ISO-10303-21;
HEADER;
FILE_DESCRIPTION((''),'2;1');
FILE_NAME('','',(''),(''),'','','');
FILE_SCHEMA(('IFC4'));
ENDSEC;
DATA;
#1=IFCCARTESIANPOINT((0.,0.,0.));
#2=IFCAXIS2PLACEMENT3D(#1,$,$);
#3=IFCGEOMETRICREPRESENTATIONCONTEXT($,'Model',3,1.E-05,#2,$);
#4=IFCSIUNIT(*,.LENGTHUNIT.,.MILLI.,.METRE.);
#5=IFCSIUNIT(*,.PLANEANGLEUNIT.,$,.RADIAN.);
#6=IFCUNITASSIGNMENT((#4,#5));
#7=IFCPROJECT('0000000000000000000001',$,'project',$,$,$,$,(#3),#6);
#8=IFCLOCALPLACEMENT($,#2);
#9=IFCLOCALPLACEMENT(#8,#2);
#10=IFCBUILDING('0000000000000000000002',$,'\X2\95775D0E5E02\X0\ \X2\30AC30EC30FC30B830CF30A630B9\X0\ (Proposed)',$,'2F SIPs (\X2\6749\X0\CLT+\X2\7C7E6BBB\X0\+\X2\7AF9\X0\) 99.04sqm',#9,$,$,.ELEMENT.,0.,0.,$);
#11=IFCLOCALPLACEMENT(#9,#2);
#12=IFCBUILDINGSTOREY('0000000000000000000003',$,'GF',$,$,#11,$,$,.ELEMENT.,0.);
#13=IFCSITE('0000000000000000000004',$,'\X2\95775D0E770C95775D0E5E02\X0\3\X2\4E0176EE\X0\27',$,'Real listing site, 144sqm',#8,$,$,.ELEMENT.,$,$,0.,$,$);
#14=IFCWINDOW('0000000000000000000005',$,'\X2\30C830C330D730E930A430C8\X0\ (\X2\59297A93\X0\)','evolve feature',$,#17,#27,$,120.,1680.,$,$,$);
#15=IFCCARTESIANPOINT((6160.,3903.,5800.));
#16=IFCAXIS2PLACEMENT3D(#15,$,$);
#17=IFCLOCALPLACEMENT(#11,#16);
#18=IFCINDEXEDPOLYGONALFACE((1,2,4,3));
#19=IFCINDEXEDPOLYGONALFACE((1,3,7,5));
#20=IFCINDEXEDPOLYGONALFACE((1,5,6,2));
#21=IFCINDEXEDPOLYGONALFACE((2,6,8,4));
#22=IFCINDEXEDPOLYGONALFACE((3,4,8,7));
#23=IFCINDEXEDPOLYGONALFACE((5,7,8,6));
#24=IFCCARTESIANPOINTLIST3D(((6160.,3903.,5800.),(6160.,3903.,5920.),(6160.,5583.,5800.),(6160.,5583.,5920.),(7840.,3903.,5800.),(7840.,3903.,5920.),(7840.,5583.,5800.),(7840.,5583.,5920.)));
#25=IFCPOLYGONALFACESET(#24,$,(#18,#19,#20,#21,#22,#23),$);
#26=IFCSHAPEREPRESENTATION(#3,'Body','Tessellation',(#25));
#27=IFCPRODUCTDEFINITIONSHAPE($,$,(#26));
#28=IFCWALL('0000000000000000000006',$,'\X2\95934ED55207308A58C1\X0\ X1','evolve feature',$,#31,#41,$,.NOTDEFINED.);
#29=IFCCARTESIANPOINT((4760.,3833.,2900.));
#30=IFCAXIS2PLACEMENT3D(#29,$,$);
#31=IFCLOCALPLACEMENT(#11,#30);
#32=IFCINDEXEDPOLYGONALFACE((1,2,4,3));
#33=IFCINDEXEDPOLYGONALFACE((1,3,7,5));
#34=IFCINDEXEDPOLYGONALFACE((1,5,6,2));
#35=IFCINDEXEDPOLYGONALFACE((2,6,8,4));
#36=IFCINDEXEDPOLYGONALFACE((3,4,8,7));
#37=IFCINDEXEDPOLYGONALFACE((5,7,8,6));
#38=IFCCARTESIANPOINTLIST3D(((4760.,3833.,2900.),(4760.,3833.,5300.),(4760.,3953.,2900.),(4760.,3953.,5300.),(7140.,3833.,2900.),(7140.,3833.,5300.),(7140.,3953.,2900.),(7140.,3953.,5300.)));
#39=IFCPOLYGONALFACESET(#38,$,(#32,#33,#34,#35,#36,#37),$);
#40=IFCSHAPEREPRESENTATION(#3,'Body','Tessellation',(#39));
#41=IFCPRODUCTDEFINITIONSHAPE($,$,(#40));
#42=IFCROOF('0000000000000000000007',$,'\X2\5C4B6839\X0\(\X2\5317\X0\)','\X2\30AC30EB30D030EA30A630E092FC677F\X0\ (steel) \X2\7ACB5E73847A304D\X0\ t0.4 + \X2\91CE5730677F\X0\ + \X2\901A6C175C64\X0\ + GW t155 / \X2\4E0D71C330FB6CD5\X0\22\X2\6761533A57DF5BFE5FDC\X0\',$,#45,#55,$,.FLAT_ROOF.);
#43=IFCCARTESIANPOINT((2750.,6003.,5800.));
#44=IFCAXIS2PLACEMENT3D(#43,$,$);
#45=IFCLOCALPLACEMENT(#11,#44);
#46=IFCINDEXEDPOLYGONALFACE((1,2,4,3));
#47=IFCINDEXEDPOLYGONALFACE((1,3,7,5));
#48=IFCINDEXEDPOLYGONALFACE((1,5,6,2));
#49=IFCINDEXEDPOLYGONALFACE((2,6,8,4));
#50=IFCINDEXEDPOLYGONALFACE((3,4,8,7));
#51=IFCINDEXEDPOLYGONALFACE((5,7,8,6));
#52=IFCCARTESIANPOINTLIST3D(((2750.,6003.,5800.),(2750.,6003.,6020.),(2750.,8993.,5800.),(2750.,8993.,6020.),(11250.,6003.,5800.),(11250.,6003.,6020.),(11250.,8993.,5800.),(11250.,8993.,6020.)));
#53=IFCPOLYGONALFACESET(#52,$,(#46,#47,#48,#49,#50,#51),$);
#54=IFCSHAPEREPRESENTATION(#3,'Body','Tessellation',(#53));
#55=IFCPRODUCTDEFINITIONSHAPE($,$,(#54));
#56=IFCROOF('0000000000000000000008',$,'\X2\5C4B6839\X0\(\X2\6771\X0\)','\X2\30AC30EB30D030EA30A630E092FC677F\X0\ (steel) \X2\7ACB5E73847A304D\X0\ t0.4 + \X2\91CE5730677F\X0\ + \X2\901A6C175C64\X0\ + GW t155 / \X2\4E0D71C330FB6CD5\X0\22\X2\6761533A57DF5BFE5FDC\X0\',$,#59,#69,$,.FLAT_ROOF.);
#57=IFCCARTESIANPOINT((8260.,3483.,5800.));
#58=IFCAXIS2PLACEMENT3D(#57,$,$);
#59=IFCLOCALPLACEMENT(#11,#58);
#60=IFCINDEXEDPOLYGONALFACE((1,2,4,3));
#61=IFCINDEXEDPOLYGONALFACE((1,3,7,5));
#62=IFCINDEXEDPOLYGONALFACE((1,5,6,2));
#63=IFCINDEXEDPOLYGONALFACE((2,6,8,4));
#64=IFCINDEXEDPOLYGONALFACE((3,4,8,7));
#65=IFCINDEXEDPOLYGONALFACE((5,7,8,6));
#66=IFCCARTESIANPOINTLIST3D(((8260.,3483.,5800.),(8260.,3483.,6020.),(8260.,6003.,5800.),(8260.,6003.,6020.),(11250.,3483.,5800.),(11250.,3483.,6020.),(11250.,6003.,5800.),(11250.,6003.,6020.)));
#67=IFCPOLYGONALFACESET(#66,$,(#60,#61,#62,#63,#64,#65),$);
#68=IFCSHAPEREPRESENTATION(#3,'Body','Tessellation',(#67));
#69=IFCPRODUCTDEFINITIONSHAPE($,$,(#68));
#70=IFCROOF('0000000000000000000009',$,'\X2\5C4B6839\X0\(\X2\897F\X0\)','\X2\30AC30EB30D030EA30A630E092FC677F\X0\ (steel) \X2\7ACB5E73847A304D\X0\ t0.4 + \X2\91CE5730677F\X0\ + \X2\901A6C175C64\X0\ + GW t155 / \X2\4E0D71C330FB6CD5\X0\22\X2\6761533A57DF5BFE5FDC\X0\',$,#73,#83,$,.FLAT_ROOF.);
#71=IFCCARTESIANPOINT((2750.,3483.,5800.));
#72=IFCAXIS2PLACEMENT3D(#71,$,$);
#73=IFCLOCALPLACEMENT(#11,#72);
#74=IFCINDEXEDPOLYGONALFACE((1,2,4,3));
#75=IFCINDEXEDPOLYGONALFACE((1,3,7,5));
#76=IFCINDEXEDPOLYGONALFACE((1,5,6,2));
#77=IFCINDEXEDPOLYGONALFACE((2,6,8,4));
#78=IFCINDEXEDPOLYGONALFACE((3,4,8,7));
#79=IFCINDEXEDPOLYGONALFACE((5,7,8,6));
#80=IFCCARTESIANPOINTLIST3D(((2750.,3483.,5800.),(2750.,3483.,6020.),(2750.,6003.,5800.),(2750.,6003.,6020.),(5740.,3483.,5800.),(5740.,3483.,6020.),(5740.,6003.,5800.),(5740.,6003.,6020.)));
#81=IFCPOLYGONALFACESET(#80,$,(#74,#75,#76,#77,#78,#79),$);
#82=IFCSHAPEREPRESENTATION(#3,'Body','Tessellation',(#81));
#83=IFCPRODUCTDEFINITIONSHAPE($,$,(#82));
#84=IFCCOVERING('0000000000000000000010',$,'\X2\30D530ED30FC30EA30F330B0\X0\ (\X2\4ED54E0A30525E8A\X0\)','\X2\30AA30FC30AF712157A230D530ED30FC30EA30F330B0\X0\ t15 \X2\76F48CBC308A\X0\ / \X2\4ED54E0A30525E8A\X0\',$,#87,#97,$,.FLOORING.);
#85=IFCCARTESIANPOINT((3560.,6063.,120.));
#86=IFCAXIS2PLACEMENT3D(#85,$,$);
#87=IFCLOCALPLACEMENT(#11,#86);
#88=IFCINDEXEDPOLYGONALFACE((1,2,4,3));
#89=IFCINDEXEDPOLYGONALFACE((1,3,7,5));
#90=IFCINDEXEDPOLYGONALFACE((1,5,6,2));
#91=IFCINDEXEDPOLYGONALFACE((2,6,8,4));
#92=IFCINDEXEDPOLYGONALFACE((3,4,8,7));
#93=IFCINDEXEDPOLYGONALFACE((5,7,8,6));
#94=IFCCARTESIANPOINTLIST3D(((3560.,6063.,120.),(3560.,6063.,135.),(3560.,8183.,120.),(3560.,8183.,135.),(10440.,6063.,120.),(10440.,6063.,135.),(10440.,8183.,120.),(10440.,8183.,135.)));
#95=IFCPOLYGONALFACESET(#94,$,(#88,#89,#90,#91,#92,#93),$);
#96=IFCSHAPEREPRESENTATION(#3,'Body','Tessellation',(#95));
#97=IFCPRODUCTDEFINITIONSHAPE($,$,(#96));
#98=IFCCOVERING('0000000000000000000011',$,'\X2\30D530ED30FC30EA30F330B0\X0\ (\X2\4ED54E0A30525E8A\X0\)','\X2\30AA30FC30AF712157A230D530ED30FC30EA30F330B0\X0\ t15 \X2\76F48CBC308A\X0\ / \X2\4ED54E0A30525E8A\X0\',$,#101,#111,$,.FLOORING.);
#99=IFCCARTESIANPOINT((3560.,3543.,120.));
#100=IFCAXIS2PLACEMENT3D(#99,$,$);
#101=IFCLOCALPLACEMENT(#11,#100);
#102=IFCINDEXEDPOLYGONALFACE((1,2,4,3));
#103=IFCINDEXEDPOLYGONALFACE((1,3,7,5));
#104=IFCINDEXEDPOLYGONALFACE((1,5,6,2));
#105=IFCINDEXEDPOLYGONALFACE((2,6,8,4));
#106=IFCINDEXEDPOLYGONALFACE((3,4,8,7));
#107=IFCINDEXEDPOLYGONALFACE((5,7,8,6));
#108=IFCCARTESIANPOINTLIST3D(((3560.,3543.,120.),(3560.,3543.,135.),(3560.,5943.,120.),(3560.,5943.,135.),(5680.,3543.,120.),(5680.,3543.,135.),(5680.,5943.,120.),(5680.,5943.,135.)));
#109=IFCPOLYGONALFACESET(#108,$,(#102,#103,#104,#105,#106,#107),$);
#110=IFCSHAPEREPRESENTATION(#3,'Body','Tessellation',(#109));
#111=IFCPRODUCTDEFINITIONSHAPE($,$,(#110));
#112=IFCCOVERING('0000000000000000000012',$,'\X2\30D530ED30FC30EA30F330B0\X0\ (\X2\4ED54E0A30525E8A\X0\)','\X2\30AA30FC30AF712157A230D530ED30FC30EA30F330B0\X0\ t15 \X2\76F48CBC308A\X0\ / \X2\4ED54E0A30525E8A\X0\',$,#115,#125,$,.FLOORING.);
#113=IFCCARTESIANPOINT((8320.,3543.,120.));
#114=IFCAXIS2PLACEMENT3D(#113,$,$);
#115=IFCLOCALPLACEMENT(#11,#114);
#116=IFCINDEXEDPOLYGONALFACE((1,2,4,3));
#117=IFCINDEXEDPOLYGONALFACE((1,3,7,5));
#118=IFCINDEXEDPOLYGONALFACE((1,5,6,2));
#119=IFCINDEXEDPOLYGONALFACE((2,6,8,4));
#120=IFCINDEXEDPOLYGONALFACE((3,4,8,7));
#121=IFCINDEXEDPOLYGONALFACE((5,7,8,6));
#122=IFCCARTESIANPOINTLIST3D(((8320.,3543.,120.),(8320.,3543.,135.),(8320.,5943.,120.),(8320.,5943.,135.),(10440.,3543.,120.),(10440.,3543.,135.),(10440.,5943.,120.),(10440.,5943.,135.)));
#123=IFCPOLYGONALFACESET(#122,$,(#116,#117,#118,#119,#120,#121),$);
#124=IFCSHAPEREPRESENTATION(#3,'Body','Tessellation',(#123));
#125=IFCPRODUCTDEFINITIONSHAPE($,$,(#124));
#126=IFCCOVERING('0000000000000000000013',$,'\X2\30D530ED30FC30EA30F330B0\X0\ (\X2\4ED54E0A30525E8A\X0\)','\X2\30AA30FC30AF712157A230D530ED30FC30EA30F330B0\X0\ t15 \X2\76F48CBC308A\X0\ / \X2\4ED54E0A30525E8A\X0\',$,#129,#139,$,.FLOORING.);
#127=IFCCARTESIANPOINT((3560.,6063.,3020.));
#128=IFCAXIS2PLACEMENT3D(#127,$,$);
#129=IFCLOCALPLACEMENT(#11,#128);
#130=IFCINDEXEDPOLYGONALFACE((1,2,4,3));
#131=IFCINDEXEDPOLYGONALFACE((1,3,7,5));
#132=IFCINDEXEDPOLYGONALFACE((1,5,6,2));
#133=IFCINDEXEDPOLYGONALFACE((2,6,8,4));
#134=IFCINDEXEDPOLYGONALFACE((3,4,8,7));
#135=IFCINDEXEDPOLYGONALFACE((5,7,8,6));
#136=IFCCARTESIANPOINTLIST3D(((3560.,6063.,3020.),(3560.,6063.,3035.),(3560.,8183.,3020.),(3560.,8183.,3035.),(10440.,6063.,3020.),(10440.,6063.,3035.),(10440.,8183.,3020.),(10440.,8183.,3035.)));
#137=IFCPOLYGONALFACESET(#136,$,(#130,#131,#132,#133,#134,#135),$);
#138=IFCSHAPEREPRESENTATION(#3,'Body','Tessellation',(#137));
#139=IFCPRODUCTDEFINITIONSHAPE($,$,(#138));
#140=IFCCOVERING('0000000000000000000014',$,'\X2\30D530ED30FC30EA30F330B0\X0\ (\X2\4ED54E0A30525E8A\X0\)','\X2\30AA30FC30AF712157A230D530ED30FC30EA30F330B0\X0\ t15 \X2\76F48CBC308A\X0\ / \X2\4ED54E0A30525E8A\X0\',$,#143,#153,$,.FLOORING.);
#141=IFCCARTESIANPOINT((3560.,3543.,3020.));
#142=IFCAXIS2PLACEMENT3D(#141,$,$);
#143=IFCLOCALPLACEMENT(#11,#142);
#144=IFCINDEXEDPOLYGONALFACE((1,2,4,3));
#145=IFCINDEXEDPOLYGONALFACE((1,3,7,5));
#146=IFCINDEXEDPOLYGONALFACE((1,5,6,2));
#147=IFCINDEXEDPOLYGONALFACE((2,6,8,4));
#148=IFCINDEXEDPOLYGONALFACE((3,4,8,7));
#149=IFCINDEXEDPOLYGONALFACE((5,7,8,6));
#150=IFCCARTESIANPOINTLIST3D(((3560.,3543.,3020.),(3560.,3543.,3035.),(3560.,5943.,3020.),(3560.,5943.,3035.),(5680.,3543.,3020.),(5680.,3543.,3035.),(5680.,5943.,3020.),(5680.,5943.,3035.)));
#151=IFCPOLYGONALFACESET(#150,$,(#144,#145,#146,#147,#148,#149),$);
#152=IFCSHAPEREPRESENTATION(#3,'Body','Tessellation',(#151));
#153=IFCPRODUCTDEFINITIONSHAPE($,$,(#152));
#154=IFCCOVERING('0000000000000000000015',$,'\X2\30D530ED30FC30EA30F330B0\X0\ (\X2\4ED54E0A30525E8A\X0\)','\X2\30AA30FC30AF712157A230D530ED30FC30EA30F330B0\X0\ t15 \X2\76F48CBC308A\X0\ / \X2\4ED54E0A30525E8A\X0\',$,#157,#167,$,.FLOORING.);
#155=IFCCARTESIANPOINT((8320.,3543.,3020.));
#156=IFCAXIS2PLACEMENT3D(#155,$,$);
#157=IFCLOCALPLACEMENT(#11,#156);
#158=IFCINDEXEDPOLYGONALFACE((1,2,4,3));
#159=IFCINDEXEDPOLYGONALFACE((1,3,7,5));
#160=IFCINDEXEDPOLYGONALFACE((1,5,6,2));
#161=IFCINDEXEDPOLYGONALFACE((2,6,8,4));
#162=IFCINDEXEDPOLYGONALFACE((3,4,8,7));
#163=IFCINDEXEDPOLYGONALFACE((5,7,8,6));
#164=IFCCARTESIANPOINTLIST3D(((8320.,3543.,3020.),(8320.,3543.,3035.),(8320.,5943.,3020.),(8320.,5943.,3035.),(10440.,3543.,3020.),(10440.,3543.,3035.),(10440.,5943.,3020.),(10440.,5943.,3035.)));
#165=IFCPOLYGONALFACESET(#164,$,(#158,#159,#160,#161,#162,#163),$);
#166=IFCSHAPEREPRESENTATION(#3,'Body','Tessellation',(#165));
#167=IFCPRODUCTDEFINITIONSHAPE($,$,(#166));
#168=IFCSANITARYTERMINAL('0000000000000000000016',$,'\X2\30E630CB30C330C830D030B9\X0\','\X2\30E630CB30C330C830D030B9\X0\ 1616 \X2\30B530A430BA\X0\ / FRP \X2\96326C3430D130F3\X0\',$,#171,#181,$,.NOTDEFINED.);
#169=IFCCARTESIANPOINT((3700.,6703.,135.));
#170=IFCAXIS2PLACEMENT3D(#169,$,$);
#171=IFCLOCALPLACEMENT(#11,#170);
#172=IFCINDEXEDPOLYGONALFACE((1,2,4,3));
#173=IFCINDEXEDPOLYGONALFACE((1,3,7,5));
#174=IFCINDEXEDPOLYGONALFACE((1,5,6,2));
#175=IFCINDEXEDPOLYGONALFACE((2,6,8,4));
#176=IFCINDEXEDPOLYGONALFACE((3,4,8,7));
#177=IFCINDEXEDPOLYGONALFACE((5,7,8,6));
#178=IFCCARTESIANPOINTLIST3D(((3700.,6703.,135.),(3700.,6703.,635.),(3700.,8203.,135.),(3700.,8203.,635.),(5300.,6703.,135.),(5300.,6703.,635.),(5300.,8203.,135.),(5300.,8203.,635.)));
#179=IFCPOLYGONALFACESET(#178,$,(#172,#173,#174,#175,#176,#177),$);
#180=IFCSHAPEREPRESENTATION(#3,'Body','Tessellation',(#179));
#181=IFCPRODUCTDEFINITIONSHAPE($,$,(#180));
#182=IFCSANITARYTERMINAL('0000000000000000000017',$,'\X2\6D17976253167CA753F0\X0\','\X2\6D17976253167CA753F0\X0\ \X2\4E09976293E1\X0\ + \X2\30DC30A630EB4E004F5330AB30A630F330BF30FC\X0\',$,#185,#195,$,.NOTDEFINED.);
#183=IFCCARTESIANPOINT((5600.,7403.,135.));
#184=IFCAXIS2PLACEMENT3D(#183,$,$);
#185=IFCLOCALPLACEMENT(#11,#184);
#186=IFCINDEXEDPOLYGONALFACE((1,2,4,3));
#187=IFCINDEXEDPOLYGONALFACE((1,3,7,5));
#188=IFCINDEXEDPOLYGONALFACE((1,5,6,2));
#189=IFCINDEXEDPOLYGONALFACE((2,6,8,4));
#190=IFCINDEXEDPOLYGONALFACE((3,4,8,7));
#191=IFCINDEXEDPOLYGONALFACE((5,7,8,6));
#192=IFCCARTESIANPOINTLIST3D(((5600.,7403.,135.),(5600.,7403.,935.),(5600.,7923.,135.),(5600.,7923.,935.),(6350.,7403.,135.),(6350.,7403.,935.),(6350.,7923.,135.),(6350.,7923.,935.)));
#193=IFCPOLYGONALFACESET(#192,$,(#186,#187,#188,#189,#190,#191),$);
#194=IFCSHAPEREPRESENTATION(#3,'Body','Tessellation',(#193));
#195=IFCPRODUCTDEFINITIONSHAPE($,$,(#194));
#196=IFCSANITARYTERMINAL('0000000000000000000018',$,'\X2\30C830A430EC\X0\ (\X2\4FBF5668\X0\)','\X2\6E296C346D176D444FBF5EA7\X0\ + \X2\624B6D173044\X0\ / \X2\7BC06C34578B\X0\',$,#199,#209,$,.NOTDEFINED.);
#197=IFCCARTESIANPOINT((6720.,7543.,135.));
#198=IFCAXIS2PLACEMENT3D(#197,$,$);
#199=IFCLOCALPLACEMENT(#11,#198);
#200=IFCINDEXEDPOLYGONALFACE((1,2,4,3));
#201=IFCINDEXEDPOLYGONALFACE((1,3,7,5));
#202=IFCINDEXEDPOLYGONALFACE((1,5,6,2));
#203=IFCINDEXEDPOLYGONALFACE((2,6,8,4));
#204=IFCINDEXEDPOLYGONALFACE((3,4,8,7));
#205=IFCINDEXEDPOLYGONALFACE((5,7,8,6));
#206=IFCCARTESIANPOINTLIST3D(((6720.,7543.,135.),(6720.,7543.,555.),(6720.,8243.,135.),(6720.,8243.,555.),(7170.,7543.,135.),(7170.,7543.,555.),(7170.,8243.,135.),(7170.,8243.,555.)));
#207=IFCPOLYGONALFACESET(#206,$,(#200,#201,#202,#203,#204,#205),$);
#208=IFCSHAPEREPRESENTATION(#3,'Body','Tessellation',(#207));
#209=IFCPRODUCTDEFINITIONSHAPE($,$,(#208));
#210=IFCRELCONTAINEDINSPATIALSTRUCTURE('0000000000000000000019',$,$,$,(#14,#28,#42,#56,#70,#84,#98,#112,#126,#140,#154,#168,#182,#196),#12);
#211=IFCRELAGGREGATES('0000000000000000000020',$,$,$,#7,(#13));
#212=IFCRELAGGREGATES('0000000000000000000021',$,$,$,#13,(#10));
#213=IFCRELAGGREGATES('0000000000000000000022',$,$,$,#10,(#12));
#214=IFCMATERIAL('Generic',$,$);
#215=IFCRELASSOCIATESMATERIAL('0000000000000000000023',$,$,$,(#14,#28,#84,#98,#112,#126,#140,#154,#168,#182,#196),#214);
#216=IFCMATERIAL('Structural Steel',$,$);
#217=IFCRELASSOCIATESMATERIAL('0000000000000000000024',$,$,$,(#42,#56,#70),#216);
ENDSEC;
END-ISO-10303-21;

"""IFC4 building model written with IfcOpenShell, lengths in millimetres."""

from ifc_helpers import new_model, si_unit, frame, frame_2d, origin, place, context, project, spatial, rectangle, extrude, material, element, save


model = new_model("IFC4")

# Units and contexts
model_context = context("Model", 3, precision=1e-05, world=origin())
ifc_project = project(units=[si_unit("LENGTHUNIT", "METRE", prefix="MILLI"), si_unit("PLANEANGLEUNIT", "RADIAN")], contexts=[model_context])

# Site, building, storey
site_placement = place(None, origin())
site = spatial("IfcSite", under=ifc_project, at=site_placement, Name="長崎県長崎市3丁目27", ObjectType="Real listing site, 144sqm", CompositionType="ELEMENT", RefElevation=0.0)
building_placement = place(site_placement, origin())
building = spatial("IfcBuilding", under=site, at=building_placement, Name="長崎市 ガレージハウス (Proposed)", ObjectType="2F SIPs (杉CLT+籾殻+竹) 99.04sqm", CompositionType="ELEMENT", ElevationOfRefHeight=0.0, ElevationOfTerrain=0.0)
storey_placement = place(building_placement, origin())
storey = spatial("IfcBuildingStorey", under=building, at=storey_placement, Name="GF", CompositionType="ELEMENT", Elevation=0.0)

# Window
ifc_material_1 = material(Name="Generic")
window_1_placement = place(storey_placement, frame((6160.0, 3903.0, 5800.0)))
element("IfcWindow", 1, at=window_1_placement, inside=storey, material=ifc_material_1, Name="トップライト (天窓)", Description="evolve feature", OverallHeight=120.0, OverallWidth=1680.0, context=model_context, shape_type="SweptSolid", body=[
    extrude(rectangle(XDim=1680.0, YDim=1680.0, at=frame_2d((840.0, 840.0))), frame((6160.0, 3903.0, 5800.0)), (0.0, 0.0, 1.0), 120.0),
])

# Wall
wall_1_placement = place(storey_placement, frame((4760.0, 3833.0, 2900.0)))
element("IfcWall", 2, at=wall_1_placement, inside=storey, material=ifc_material_1, Name="間仕切り壁 X1", Description="evolve feature", PredefinedType="NOTDEFINED", context=model_context, shape_type="SweptSolid", body=[
    extrude(rectangle(XDim=2380.0, YDim=120.0, at=frame_2d((1190.0, 60.0))), frame((4760.0, 3833.0, 2900.0)), (0.0, 0.0, 1.0), 2400.0),
])

# Roofs
ifc_material_2 = material(Name="Structural Steel")
roof_1_placement = place(storey_placement, frame((2750.0, 6003.0, 5800.0)))
element("IfcRoof", 3, at=roof_1_placement, inside=storey, material=ifc_material_2, Name="屋根(北)", Description="ガルバリウム鋼板 (steel) 立平葺き t0.4 + 野地板 + 通気層 + GW t155 / 不燃・法22条区域対応", PredefinedType="FLAT_ROOF", context=model_context, shape_type="SweptSolid", body=[
    extrude(rectangle(XDim=8500.0, YDim=2990.0, at=frame_2d((4250.0, 1495.0))), frame((2750.0, 6003.0, 5800.0)), (0.0, 0.0, 1.0), 220.0),
])
roof_2_placement = place(storey_placement, frame((8260.0, 3483.0, 5800.0)))
element("IfcRoof", 4, at=roof_2_placement, inside=storey, material=ifc_material_2, Name="屋根(東)", Description="ガルバリウム鋼板 (steel) 立平葺き t0.4 + 野地板 + 通気層 + GW t155 / 不燃・法22条区域対応", PredefinedType="FLAT_ROOF", context=model_context, shape_type="SweptSolid", body=[
    extrude(rectangle(XDim=2990.0, YDim=2520.0, at=frame_2d((1495.0, 1260.0))), frame((8260.0, 3483.0, 5800.0)), (0.0, 0.0, 1.0), 220.0),
])
roof_3_placement = place(storey_placement, frame((2750.0, 3483.0, 5800.0)))
element("IfcRoof", 5, at=roof_3_placement, inside=storey, material=ifc_material_2, Name="屋根(西)", Description="ガルバリウム鋼板 (steel) 立平葺き t0.4 + 野地板 + 通気層 + GW t155 / 不燃・法22条区域対応", PredefinedType="FLAT_ROOF", context=model_context, shape_type="SweptSolid", body=[
    extrude(rectangle(XDim=2990.0, YDim=2520.0, at=frame_2d((1495.0, 1260.0))), frame((2750.0, 3483.0, 5800.0)), (0.0, 0.0, 1.0), 220.0),
])

# Coverings
covering_1_placement = place(storey_placement, frame((3560.0, 6063.0, 120.0)))
element("IfcCovering", 6, at=covering_1_placement, inside=storey, material=ifc_material_1, Name="フローリング (仕上げ床)", Description="オーク無垢フローリング t15 直貼り / 仕上げ床", PredefinedType="FLOORING", context=model_context, shape_type="SweptSolid", body=[
    extrude(rectangle(XDim=6880.0, YDim=2120.0, at=frame_2d((3440.0, 1060.0))), frame((3560.0, 6063.0, 120.0)), (0.0, 0.0, 1.0), 15.0),
])
covering_2_placement = place(storey_placement, frame((3560.0, 3543.0, 120.0)))
element("IfcCovering", 7, at=covering_2_placement, inside=storey, material=ifc_material_1, Name="フローリング (仕上げ床)", Description="オーク無垢フローリング t15 直貼り / 仕上げ床", PredefinedType="FLOORING", context=model_context, shape_type="SweptSolid", body=[
    extrude(rectangle(XDim=2120.0, YDim=2400.0, at=frame_2d((1060.0, 1200.0))), frame((3560.0, 3543.0, 120.0)), (0.0, 0.0, 1.0), 15.0),
])
covering_3_placement = place(storey_placement, frame((8320.0, 3543.0, 120.0)))
element("IfcCovering", 8, at=covering_3_placement, inside=storey, material=ifc_material_1, Name="フローリング (仕上げ床)", Description="オーク無垢フローリング t15 直貼り / 仕上げ床", PredefinedType="FLOORING", context=model_context, shape_type="SweptSolid", body=[
    extrude(rectangle(XDim=2120.0, YDim=2400.0, at=frame_2d((1060.0, 1200.0))), frame((8320.0, 3543.0, 120.0)), (0.0, 0.0, 1.0), 15.0),
])
covering_4_placement = place(storey_placement, frame((3560.0, 6063.0, 3020.0)))
element("IfcCovering", 9, at=covering_4_placement, inside=storey, material=ifc_material_1, Name="フローリング (仕上げ床)", Description="オーク無垢フローリング t15 直貼り / 仕上げ床", PredefinedType="FLOORING", context=model_context, shape_type="SweptSolid", body=[
    extrude(rectangle(XDim=6880.0, YDim=2120.0, at=frame_2d((3440.0, 1060.0))), frame((3560.0, 6063.0, 3020.0)), (0.0, 0.0, 1.0), 15.0),
])
covering_5_placement = place(storey_placement, frame((3560.0, 3543.0, 3020.0)))
element("IfcCovering", 10, at=covering_5_placement, inside=storey, material=ifc_material_1, Name="フローリング (仕上げ床)", Description="オーク無垢フローリング t15 直貼り / 仕上げ床", PredefinedType="FLOORING", context=model_context, shape_type="SweptSolid", body=[
    extrude(rectangle(XDim=2120.0, YDim=2400.0, at=frame_2d((1060.0, 1200.0))), frame((3560.0, 3543.0, 3020.0)), (0.0, 0.0, 1.0), 15.0),
])
covering_6_placement = place(storey_placement, frame((8320.0, 3543.0, 3020.0)))
element("IfcCovering", 11, at=covering_6_placement, inside=storey, material=ifc_material_1, Name="フローリング (仕上げ床)", Description="オーク無垢フローリング t15 直貼り / 仕上げ床", PredefinedType="FLOORING", context=model_context, shape_type="SweptSolid", body=[
    extrude(rectangle(XDim=2120.0, YDim=2400.0, at=frame_2d((1060.0, 1200.0))), frame((8320.0, 3543.0, 3020.0)), (0.0, 0.0, 1.0), 15.0),
])

# Sanitary terminals
sanitary_terminal_1_placement = place(storey_placement, frame((3700.0, 6703.0, 135.0)))
element("IfcSanitaryTerminal", 12, at=sanitary_terminal_1_placement, inside=storey, material=ifc_material_1, Name="ユニットバス", Description="ユニットバス 1616 サイズ / FRP 防水パン", PredefinedType="NOTDEFINED", context=model_context, shape_type="SweptSolid", body=[
    extrude(rectangle(XDim=1600.0, YDim=1500.0, at=frame_2d((800.0, 750.0))), frame((3700.0, 6703.0, 135.0)), (0.0, 0.0, 1.0), 500.0),
])
sanitary_terminal_2_placement = place(storey_placement, frame((5600.0, 7403.0, 135.0)))
element("IfcSanitaryTerminal", 13, at=sanitary_terminal_2_placement, inside=storey, material=ifc_material_1, Name="洗面化粧台", Description="洗面化粧台 三面鏡 + ボウル一体カウンター", PredefinedType="NOTDEFINED", context=model_context, shape_type="SweptSolid", body=[
    extrude(rectangle(XDim=750.0, YDim=520.0, at=frame_2d((375.0, 260.0))), frame((5600.0, 7403.0, 135.0)), (0.0, 0.0, 1.0), 800.0),
])
sanitary_terminal_3_placement = place(storey_placement, frame((6720.0, 7543.0, 135.0)))
element("IfcSanitaryTerminal", 14, at=sanitary_terminal_3_placement, inside=storey, material=ifc_material_1, Name="トイレ (便器)", Description="温水洗浄便座 + 手洗い / 節水型", PredefinedType="NOTDEFINED", context=model_context, shape_type="SweptSolid", body=[
    extrude(rectangle(XDim=450.0, YDim=700.0, at=frame_2d((225.0, 350.0))), frame((6720.0, 7543.0, 135.0)), (0.0, 0.0, 1.0), 420.0),
])

save(model, "model.ifc")
